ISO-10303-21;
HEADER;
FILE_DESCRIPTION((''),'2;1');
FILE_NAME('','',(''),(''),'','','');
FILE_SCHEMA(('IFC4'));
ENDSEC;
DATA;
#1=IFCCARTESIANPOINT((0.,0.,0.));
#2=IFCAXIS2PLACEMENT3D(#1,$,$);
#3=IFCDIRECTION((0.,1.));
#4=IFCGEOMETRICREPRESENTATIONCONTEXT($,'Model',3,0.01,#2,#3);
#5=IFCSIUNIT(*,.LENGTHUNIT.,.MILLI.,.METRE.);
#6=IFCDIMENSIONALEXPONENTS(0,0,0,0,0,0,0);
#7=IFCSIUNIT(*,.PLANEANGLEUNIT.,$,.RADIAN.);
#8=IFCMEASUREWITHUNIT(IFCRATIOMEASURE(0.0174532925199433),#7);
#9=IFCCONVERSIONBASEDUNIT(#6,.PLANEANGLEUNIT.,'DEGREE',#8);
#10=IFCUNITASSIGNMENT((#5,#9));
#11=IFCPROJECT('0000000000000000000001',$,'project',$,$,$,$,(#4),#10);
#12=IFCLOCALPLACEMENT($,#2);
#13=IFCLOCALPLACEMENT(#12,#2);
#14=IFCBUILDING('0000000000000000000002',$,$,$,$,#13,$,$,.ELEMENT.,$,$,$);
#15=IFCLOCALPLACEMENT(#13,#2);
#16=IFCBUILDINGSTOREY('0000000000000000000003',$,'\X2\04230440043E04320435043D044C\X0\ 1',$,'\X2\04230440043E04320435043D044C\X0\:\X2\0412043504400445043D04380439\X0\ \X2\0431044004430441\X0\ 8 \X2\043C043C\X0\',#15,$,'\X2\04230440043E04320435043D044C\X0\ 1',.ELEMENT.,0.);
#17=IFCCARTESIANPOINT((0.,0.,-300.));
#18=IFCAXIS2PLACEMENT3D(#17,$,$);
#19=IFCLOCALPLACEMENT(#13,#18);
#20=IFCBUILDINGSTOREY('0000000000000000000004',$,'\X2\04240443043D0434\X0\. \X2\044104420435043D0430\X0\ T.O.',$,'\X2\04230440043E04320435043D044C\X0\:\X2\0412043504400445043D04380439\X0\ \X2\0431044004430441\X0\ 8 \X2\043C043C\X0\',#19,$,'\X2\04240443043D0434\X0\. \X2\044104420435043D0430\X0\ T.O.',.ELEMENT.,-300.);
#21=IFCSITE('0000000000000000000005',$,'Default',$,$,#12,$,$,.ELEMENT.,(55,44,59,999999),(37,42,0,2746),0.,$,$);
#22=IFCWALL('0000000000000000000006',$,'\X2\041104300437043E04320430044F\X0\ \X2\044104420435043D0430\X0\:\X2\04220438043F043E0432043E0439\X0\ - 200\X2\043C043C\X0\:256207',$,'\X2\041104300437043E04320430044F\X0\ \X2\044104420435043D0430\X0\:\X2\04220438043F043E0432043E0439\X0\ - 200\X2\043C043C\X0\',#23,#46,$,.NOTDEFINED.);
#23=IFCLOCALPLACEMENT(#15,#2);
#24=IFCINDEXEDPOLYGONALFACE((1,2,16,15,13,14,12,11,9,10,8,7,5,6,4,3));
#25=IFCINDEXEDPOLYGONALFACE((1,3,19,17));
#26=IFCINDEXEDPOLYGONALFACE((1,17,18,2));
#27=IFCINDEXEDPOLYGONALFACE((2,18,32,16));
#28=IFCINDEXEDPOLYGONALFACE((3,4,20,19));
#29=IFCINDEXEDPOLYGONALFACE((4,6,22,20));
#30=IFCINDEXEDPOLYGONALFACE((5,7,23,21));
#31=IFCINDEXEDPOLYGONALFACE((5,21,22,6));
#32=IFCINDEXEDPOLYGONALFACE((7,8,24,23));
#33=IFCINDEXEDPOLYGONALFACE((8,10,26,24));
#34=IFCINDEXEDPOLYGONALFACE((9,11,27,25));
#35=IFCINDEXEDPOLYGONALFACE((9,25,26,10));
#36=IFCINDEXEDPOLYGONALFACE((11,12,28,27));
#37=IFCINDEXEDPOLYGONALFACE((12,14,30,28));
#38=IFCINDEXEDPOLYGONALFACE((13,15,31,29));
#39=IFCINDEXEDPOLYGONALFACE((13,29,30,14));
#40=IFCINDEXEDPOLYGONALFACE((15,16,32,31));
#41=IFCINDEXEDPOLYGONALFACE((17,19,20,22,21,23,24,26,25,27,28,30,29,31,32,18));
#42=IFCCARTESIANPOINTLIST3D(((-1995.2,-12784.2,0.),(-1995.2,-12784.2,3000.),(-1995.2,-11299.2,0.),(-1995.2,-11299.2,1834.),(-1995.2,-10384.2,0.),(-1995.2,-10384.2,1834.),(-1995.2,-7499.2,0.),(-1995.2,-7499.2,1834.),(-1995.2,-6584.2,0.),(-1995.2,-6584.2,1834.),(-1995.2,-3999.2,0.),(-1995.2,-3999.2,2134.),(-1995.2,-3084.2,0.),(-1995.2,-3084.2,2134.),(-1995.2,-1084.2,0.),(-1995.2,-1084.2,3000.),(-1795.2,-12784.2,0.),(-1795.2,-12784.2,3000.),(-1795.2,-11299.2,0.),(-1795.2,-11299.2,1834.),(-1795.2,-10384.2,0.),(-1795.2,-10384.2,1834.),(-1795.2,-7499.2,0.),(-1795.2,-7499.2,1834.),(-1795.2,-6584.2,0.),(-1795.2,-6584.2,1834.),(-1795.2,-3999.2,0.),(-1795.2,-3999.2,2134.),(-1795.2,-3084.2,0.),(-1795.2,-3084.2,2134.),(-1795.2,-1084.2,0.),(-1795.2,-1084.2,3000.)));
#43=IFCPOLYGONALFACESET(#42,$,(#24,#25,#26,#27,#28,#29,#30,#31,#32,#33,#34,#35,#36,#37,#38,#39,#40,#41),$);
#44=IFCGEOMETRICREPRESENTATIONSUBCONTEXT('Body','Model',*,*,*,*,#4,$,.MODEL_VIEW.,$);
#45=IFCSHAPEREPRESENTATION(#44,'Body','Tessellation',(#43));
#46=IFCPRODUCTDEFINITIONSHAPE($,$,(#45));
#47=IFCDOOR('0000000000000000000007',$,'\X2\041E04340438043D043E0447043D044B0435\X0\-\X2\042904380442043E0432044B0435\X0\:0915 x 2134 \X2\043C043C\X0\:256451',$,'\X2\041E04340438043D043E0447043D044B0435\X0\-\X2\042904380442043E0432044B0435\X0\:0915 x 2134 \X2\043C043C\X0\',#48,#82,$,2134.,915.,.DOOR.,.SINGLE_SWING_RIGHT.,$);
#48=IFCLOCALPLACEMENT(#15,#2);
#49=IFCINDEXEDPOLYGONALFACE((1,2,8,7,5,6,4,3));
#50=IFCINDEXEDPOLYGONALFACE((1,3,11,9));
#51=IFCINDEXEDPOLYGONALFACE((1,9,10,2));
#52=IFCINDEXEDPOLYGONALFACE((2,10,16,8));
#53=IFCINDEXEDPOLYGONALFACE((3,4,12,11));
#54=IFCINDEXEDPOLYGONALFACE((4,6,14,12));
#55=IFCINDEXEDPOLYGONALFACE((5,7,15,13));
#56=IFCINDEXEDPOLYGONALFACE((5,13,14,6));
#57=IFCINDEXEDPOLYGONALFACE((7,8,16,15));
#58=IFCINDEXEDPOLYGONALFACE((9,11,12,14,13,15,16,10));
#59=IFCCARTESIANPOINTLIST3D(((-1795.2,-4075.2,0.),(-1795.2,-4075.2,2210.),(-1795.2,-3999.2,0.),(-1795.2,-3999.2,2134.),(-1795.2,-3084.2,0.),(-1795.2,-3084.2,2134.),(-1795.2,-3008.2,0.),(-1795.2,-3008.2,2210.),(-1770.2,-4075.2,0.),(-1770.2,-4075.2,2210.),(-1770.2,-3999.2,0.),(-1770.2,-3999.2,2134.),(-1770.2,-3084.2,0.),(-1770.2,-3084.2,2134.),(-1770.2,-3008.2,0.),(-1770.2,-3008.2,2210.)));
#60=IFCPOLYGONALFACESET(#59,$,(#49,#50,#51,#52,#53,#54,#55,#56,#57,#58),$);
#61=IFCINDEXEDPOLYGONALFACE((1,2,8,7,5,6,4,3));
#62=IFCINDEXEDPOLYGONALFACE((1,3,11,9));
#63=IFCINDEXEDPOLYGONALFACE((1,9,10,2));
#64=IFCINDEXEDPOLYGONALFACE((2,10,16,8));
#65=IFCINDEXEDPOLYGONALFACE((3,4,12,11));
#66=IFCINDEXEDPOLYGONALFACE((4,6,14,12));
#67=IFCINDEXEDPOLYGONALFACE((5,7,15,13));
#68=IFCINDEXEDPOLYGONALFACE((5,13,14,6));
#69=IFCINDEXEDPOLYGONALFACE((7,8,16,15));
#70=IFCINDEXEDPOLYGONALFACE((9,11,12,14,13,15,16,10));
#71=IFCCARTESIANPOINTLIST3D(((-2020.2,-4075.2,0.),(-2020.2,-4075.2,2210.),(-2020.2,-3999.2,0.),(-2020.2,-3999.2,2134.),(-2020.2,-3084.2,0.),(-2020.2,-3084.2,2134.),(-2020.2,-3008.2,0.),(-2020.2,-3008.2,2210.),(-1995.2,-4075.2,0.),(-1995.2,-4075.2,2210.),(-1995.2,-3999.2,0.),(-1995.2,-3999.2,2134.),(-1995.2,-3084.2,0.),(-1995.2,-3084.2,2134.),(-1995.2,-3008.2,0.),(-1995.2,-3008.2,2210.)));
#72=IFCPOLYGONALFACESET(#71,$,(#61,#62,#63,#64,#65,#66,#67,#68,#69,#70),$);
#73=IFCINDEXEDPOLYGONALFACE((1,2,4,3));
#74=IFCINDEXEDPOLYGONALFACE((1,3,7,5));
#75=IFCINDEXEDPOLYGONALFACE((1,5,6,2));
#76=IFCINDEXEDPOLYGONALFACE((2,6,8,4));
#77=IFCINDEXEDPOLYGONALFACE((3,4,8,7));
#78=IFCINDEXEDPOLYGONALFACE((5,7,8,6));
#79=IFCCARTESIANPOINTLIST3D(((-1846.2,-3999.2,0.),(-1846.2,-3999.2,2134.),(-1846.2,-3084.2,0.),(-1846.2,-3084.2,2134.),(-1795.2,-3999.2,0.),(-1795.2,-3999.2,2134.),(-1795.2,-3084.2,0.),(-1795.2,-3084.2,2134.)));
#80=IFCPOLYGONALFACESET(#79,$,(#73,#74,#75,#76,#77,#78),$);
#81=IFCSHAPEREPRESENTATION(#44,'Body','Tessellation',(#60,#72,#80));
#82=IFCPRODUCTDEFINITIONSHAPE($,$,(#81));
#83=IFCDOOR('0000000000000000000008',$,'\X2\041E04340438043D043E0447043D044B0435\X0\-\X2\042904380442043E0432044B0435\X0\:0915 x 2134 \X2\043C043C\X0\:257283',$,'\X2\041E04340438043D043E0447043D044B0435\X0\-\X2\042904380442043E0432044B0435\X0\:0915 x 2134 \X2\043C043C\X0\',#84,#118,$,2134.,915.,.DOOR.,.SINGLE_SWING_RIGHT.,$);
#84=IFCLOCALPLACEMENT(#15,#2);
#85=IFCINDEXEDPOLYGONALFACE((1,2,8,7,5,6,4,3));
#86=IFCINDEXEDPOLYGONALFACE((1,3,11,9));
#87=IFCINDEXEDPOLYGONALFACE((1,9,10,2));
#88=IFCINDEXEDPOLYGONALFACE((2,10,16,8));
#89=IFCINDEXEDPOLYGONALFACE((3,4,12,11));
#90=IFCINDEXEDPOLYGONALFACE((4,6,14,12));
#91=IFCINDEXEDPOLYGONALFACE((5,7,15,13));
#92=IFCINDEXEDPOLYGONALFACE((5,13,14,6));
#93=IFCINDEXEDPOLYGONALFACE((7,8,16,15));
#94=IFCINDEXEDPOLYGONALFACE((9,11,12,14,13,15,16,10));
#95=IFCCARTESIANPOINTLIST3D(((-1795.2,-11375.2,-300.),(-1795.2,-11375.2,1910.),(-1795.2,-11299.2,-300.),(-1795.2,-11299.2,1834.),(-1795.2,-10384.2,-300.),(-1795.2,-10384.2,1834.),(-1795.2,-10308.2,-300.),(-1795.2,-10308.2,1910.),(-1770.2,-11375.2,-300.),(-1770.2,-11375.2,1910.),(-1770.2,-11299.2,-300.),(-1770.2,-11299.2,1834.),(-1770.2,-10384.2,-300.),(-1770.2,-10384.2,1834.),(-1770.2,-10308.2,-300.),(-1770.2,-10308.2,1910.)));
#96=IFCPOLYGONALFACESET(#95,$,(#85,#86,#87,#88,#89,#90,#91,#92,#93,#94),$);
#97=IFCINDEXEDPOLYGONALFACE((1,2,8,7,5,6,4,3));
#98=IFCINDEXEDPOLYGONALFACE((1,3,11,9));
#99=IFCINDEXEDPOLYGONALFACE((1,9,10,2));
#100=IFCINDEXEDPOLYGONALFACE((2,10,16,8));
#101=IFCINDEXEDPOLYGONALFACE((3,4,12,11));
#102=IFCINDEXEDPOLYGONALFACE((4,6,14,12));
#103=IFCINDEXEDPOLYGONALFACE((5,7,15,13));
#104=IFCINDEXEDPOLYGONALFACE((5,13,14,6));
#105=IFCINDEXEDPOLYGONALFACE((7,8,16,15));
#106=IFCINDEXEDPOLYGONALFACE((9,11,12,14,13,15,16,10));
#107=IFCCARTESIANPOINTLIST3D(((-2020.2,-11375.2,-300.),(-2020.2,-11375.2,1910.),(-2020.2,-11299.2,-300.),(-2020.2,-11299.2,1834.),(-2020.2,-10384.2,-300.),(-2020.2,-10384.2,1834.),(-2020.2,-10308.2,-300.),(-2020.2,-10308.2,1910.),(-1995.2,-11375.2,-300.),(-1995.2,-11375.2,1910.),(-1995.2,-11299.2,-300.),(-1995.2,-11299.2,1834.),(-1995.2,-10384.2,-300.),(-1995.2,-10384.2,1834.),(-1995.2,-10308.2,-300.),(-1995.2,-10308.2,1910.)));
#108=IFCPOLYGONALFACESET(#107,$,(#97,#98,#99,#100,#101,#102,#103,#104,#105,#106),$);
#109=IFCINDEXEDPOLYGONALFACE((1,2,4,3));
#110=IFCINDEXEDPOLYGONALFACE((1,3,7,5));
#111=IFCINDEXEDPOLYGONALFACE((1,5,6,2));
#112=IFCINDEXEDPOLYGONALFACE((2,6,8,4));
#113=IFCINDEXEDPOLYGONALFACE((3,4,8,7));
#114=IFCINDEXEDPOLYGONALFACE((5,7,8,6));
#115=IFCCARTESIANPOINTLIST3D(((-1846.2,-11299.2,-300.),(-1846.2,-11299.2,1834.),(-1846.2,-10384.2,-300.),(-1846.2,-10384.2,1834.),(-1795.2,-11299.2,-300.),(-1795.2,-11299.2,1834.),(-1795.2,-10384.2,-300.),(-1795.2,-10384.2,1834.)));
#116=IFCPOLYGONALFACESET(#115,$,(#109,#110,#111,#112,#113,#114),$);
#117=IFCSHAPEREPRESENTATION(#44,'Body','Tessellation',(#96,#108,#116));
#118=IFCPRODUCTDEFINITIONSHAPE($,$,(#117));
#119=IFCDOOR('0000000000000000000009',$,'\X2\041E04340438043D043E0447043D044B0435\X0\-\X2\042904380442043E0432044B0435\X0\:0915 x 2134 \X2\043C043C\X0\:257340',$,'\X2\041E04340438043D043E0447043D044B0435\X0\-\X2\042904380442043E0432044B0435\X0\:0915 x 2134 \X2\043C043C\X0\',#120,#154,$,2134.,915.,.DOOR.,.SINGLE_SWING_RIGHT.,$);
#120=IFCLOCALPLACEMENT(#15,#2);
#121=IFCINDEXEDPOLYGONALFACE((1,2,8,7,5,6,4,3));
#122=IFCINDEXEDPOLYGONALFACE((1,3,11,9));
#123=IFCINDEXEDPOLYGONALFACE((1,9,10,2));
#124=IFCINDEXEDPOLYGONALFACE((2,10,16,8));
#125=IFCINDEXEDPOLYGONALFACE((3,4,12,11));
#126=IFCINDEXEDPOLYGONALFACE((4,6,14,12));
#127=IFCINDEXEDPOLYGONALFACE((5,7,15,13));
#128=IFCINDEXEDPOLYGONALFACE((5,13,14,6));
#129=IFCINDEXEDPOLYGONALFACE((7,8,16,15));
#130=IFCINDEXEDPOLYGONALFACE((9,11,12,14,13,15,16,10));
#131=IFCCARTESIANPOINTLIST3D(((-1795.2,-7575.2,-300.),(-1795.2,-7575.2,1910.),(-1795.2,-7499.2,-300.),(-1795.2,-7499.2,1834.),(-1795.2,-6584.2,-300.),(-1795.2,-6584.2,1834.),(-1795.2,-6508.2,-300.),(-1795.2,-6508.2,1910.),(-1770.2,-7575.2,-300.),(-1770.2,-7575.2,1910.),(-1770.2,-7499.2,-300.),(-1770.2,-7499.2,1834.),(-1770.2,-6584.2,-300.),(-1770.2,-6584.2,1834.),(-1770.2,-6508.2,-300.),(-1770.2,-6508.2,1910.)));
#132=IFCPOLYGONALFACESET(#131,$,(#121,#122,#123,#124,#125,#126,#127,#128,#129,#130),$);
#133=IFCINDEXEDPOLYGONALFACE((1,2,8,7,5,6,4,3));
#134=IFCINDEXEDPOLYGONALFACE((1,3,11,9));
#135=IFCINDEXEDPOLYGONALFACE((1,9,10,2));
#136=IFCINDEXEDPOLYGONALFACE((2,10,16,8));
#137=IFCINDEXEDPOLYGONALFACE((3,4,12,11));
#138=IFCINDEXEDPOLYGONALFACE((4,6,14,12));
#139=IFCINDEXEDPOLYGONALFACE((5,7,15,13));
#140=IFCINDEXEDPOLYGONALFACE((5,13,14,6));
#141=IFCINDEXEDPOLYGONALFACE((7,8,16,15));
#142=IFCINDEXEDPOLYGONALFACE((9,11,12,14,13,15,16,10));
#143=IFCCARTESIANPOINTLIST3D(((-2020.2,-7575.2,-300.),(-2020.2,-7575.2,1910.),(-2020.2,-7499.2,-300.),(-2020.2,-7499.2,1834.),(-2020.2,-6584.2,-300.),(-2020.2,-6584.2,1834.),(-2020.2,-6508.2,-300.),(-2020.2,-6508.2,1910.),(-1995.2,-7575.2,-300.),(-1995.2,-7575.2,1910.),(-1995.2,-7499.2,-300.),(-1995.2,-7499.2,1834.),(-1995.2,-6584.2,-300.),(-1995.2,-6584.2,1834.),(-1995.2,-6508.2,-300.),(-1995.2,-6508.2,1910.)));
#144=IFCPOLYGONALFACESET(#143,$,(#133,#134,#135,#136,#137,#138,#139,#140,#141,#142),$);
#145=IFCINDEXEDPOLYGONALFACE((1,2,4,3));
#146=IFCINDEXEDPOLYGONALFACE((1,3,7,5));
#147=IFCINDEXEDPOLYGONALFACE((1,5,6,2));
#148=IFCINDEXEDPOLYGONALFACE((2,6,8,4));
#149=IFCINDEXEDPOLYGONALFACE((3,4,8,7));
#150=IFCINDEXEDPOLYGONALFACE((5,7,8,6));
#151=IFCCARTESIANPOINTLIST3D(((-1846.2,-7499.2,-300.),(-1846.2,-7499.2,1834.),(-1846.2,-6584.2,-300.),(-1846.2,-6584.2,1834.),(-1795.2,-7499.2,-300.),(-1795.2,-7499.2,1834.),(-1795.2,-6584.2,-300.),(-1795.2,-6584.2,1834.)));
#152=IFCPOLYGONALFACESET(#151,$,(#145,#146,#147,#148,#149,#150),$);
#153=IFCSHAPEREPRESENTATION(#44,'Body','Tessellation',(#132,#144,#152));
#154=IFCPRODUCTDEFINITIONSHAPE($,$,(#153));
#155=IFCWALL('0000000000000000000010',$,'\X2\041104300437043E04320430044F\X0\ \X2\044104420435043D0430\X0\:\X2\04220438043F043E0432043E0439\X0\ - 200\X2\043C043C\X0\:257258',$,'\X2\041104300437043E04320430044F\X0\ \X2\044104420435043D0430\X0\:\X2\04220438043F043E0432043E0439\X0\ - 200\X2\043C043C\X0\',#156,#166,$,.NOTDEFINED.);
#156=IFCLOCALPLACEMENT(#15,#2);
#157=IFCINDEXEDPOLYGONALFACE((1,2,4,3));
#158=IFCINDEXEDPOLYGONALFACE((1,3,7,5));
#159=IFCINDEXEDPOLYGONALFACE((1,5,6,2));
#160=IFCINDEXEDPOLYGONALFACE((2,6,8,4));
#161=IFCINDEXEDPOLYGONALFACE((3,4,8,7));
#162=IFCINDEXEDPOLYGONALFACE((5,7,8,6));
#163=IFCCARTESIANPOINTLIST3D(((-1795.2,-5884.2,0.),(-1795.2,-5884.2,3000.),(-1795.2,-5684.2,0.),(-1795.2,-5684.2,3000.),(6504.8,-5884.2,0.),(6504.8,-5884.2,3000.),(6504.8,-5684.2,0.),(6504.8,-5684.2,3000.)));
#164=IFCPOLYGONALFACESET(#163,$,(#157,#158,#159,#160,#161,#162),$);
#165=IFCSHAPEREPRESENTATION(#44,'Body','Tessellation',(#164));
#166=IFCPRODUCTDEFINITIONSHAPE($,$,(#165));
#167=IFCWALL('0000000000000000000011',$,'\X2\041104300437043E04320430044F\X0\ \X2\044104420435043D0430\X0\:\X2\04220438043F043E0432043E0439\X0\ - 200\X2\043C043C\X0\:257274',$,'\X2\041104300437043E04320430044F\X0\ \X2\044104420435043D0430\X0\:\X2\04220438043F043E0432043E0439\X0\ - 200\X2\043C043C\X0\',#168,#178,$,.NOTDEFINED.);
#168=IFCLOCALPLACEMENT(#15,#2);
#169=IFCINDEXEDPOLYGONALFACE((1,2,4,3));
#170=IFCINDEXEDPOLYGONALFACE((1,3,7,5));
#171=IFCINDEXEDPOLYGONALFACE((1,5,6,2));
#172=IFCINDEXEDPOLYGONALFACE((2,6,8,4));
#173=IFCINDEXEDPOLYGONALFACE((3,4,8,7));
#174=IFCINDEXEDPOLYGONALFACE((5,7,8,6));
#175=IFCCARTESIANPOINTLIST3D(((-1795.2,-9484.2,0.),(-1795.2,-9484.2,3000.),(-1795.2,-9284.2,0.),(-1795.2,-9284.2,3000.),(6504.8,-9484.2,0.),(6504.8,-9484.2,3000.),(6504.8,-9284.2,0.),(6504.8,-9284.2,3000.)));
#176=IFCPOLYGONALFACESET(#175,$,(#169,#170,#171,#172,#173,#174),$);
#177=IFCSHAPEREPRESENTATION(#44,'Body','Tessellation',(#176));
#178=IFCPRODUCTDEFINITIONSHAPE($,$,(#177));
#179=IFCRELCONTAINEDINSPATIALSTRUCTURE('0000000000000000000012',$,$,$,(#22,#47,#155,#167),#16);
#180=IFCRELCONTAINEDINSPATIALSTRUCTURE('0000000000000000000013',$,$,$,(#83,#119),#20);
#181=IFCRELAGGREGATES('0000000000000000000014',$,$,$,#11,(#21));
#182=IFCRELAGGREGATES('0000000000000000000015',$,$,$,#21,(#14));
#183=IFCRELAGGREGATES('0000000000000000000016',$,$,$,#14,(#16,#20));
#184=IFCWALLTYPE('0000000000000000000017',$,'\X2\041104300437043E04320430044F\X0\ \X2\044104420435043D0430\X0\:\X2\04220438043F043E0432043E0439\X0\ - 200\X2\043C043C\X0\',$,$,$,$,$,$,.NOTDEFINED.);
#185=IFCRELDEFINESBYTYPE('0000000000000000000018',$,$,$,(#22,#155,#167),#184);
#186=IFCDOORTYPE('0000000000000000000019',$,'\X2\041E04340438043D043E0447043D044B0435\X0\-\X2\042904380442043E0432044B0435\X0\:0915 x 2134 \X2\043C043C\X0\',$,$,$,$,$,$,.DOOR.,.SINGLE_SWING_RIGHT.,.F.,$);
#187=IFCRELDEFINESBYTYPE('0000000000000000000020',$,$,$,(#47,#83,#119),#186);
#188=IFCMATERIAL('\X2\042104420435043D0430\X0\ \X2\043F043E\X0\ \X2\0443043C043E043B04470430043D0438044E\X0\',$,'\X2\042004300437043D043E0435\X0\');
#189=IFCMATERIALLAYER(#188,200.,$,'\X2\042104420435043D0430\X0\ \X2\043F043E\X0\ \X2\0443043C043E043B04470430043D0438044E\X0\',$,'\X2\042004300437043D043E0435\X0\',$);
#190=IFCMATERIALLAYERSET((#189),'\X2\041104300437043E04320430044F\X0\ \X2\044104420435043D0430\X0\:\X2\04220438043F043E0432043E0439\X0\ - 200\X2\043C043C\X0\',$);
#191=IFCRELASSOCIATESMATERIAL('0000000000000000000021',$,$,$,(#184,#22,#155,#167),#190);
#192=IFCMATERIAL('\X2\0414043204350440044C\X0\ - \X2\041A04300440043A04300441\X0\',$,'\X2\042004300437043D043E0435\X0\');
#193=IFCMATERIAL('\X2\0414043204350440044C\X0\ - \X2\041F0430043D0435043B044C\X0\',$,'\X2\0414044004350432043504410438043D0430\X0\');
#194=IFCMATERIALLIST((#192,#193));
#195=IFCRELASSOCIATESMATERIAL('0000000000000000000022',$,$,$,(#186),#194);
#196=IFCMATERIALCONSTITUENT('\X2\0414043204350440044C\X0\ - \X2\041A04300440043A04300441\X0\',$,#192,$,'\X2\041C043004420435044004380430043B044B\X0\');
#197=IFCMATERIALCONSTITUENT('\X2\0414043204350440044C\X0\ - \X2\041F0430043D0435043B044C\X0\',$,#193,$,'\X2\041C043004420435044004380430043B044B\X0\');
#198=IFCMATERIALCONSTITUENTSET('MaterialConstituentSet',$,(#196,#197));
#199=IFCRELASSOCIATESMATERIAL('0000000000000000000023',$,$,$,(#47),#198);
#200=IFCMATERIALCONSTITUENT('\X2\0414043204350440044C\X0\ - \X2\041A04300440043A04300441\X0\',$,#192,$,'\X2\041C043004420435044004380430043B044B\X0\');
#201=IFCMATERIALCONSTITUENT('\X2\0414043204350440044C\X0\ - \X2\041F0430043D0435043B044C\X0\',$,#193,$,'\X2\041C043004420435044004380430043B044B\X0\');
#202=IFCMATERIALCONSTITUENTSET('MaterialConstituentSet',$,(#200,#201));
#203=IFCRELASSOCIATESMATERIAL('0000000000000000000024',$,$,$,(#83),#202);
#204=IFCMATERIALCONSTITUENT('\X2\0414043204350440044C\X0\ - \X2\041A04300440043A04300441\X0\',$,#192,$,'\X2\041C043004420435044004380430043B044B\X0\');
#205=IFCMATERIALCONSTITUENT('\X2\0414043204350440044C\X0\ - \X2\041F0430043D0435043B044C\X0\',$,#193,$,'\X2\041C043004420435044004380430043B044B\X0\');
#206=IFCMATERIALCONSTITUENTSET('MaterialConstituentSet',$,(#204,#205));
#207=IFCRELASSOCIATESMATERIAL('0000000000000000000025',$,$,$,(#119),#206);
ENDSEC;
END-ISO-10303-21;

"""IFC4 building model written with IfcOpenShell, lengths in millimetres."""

from ifc_helpers import new_model, entity, si_unit, converted_unit, direction, frame, frame_2d, origin, place, context, subcontext, project, spatial, polyline, rectangle, outline, extrude, source, transform, mapped, material, material_list, layer, layer_set, layer_usage, constituent, constituent_set, type_object, type_shapes, element, fill, save


model = new_model("IFC4")

# Units and contexts
model_context = context("Model", 3, precision=0.01, world=origin(), true_north=direction((0.0, 1.0)))
body_context = subcontext(model_context, "Body", "Model", "MODEL_VIEW")
ifc_project = project(units=[si_unit("LENGTHUNIT", "METRE", prefix="MILLI"), converted_unit("PLANEANGLEUNIT", "DEGREE", entity("IfcRatioMeasure", 0.0174532925199433), si_unit("PLANEANGLEUNIT", "RADIAN"), dimensions=[0, 0, 0, 0, 0, 0, 0])], contexts=[model_context])

# Site, building, storey
site_placement = place(None, origin())
site = spatial("IfcSite", under=ifc_project, at=site_placement, Name="Default", CompositionType="ELEMENT", RefLatitude=(55, 44, 59, 999999), RefLongitude=(37, 42, 0, 2746), RefElevation=0.0)
building_placement = place(site_placement, origin())
building = spatial("IfcBuilding", under=site, at=building_placement, CompositionType="ELEMENT")
storey_1_placement = place(building_placement, origin())
storey_1 = spatial("IfcBuildingStorey", under=building, at=storey_1_placement, Name="Уровень 1", ObjectType="Уровень:Верхний брус 8 мм", LongName="Уровень 1", CompositionType="ELEMENT", Elevation=0.0)

# Shared definitions
ifc_material_1 = material(Name="Стена по умолчанию", Category="Разное")
ifc_layer = layer(ifc_material_1, 200.0, Name="Стена по умолчанию", Category="Разное")
ifc_layer_set = layer_set([ifc_layer], Name="Базовая стена:Типовой - 200мм")
wall_type = type_object("IfcWallType", Name="Базовая стена:Типовой - 200мм", PredefinedType="NOTDEFINED", material=ifc_layer_set)

# Shared definitions
ifc_material_2 = material(Name="Дверь - Каркас", Category="Разное")
ifc_material_3 = material(Name="Дверь - Панель", Category="Древесина")
ifc_material_list_1 = material_list([ifc_material_2, ifc_material_3])
door_type = type_object("IfcDoorType", Name="Одиночные-Щитовые:0915 x 2134 мм", OperationType="SINGLE_SWING_RIGHT", ParameterTakesPrecedence=False, PredefinedType="DOOR", material=ifc_material_list_1)
shared_shape_1 = source(origin(), body_context, "Body", "SweptSolid", [
    extrude(outline(polyline([(-533.5, -1124.0), (533.5, -1124.0), (533.5, 1086.0), (457.5, 1086.0), (457.5, -1048.0), (-457.5, -1048.0), (-457.5, 1086.0), (-533.5, 1086.0), (-533.5, -1124.0)])), frame((457.5, 200.0, 1086.0), z_axis=(0.0, 1.0, 0.0), x_axis=(1.0, 0.0, 0.0)), (0.0, 0.0, 1.0), 25.0),
    extrude(outline(polyline([(-1124.0, -533.5), (1086.0, -533.5), (1086.0, -457.5), (-1048.0, -457.5), (-1048.0, 457.5), (1086.0, 457.5), (1086.0, 533.5), (-1124.0, 533.5), (-1124.0, -533.5)])), frame((457.5, -25.0, 1086.0), z_axis=(0.0, 1.0, 0.0), x_axis=(0.0, 0.0, -1.0)), (0.0, 0.0, 1.0), 25.0),
    extrude(rectangle(XDim=51.0, YDim=915.0, at=frame_2d((0.0, 0.0), x_axis=(1.0, 0.0))), frame((457.5, 174.5, 0.0), z_axis=(0.0, 0.0, 1.0), x_axis=(0.0, 1.0, 0.0)), (0.0, 0.0, 1.0), 2134.0),
])
type_shapes(door_type, [shared_shape_1])

# Wall, openings, door
ifc_layer_usage_1 = layer_usage(ifc_layer_set, "AXIS2", "NEGATIVE", 100.0)
wall_1_placement = place(storey_1_placement, frame((-1895.2, -1084.2, 0.0), z_axis=(0.0, 0.0, 1.0), x_axis=(0.0, -1.0, 0.0)))
wall_1 = element("IfcWall", 1, at=wall_1_placement, inside=storey_1, type_object=wall_type, material=ifc_layer_usage_1, Name="Базовая стена:Типовой - 200мм:256207", ObjectType="Базовая стена:Типовой - 200мм", PredefinedType="NOTDEFINED", context=body_context, shape_type="SweptSolid", body=[
    extrude(rectangle(XDim=11700.0, YDim=200.0, at=frame_2d((5850.0, 0.0), x_axis=(-1.0, 0.0))), origin(), (0.0, 0.0, 1.0), 3000.0),
])
opening_1_placement = place(wall_1_placement, frame((2000.0, -100.0, 0.0)))
opening_1 = element("IfcOpeningElement", 2, at=opening_1_placement, cuts=wall_1, ObjectType="Opening", PredefinedType="OPENING", context=body_context, shape_type="SweptSolid", body=[
    extrude(rectangle(XDim=915.0, YDim=2134.0, at=frame_2d((1067.0, 457.5), x_axis=(0.0, 1.0))), frame((0.0, 0.0, 0.0), z_axis=(0.0, 1.0, 0.0), x_axis=(0.0, 0.0, 1.0)), (0.0, 0.0, 1.0), 200.0),
])
opening_2_placement = place(wall_1_placement, frame((9300.0, -100.0, -300.0)))
opening_2 = element("IfcOpeningElement", 3, at=opening_2_placement, cuts=wall_1, ObjectType="Opening", PredefinedType="OPENING", context=body_context, shape_type="SweptSolid", body=[
    extrude(rectangle(XDim=915.0, YDim=2134.0, at=frame_2d((1067.0, 457.5), x_axis=(0.0, 1.0))), frame((0.0, 0.0, 0.0), z_axis=(0.0, 1.0, 0.0), x_axis=(0.0, 0.0, 1.0)), (0.0, 0.0, 1.0), 200.0),
])
opening_3_placement = place(wall_1_placement, frame((5500.0, -100.0, -300.0)))
opening_3 = element("IfcOpeningElement", 4, at=opening_3_placement, cuts=wall_1, ObjectType="Opening", PredefinedType="OPENING", context=body_context, shape_type="SweptSolid", body=[
    extrude(rectangle(XDim=915.0, YDim=2134.0, at=frame_2d((1067.0, 457.5), x_axis=(0.0, 1.0))), frame((0.0, 0.0, 0.0), z_axis=(0.0, 1.0, 0.0), x_axis=(0.0, 0.0, 1.0)), (0.0, 0.0, 1.0), 200.0),
])
ifc_constituent_1 = constituent(ifc_material_2, Name="Дверь - Каркас", Category="Материалы")
ifc_constituent_2 = constituent(ifc_material_3, Name="Дверь - Панель", Category="Материалы")
ifc_constituent_set_1 = constituent_set(constituents=[ifc_constituent_1, ifc_constituent_2], Name="MaterialConstituentSet")
door_1_placement = place(opening_1_placement, origin())
door_1 = element("IfcDoor", 5, at=door_1_placement, inside=storey_1, type_object=door_type, material=ifc_constituent_set_1, Name="Одиночные-Щитовые:0915 x 2134 мм:256451", ObjectType="Одиночные-Щитовые:0915 x 2134 мм", OperationType="SINGLE_SWING_RIGHT", OverallHeight=2134.0, OverallWidth=915.0, PredefinedType="DOOR", context=body_context, shape_type="MappedRepresentation", body=[
    mapped(shared_shape_1, transform((0.0, 0.0, 0.0), scale=1.0)),
])
fill(opening_1, door_1)

# Shared definitions
storey_2_placement = place(building_placement, frame((0.0, 0.0, -300.0)))
storey_2 = spatial("IfcBuildingStorey", under=building, at=storey_2_placement, Name="Фунд. стена T.O.", ObjectType="Уровень:Верхний брус 8 мм", LongName="Фунд. стена T.O.", CompositionType="ELEMENT", Elevation=-300.0)

# Doors
ifc_constituent_3 = constituent(ifc_material_2, Name="Дверь - Каркас", Category="Материалы")
ifc_constituent_4 = constituent(ifc_material_3, Name="Дверь - Панель", Category="Материалы")
ifc_constituent_set_2 = constituent_set(constituents=[ifc_constituent_3, ifc_constituent_4], Name="MaterialConstituentSet")
door_2_placement = place(opening_2_placement, origin())
door_2 = element("IfcDoor", 6, at=door_2_placement, inside=storey_2, type_object=door_type, material=ifc_constituent_set_2, Name="Одиночные-Щитовые:0915 x 2134 мм:257283", ObjectType="Одиночные-Щитовые:0915 x 2134 мм", OperationType="SINGLE_SWING_RIGHT", OverallHeight=2134.0, OverallWidth=915.0, PredefinedType="DOOR", context=body_context, shape_type="MappedRepresentation", body=[
    mapped(shared_shape_1, transform((0.0, 0.0, 0.0), scale=1.0)),
])
fill(opening_2, door_2)
ifc_constituent_5 = constituent(ifc_material_2, Name="Дверь - Каркас", Category="Материалы")
ifc_constituent_6 = constituent(ifc_material_3, Name="Дверь - Панель", Category="Материалы")
ifc_constituent_set_3 = constituent_set(constituents=[ifc_constituent_5, ifc_constituent_6], Name="MaterialConstituentSet")
door_3_placement = place(opening_3_placement, origin())
door_3 = element("IfcDoor", 7, at=door_3_placement, inside=storey_2, type_object=door_type, material=ifc_constituent_set_3, Name="Одиночные-Щитовые:0915 x 2134 мм:257340", ObjectType="Одиночные-Щитовые:0915 x 2134 мм", OperationType="SINGLE_SWING_RIGHT", OverallHeight=2134.0, OverallWidth=915.0, PredefinedType="DOOR", context=body_context, shape_type="MappedRepresentation", body=[
    mapped(shared_shape_1, transform((0.0, 0.0, 0.0), scale=1.0)),
])
fill(opening_3, door_3)

# Walls
ifc_layer_usage_2 = layer_usage(ifc_layer_set, "AXIS2", "NEGATIVE", 100.0)
wall_2_placement = place(storey_1_placement, frame((6504.8, -5784.2, 0.0), z_axis=(0.0, 0.0, 1.0), x_axis=(-1.0, 0.0, 0.0)))
element("IfcWall", 8, at=wall_2_placement, inside=storey_1, type_object=wall_type, material=ifc_layer_usage_2, Name="Базовая стена:Типовой - 200мм:257258", ObjectType="Базовая стена:Типовой - 200мм", PredefinedType="NOTDEFINED", context=body_context, shape_type="SweptSolid", body=[
    extrude(rectangle(XDim=8300.0, YDim=200.0, at=frame_2d((4150.0, 0.0), x_axis=(-1.0, 0.0))), origin(), (0.0, 0.0, 1.0), 3000.0),
])
ifc_layer_usage_3 = layer_usage(ifc_layer_set, "AXIS2", "NEGATIVE", 100.0)
wall_3_placement = place(storey_1_placement, frame((6504.8, -9384.2, 0.0), z_axis=(0.0, 0.0, 1.0), x_axis=(-1.0, 0.0, 0.0)))
element("IfcWall", 9, at=wall_3_placement, inside=storey_1, type_object=wall_type, material=ifc_layer_usage_3, Name="Базовая стена:Типовой - 200мм:257274", ObjectType="Базовая стена:Типовой - 200мм", PredefinedType="NOTDEFINED", context=body_context, shape_type="SweptSolid", body=[
    extrude(rectangle(XDim=8300.0, YDim=200.0, at=frame_2d((4150.0, 0.0), x_axis=(-1.0, 0.0))), origin(), (0.0, 0.0, 1.0), 3000.0),
])

save(model, "model.ifc")
